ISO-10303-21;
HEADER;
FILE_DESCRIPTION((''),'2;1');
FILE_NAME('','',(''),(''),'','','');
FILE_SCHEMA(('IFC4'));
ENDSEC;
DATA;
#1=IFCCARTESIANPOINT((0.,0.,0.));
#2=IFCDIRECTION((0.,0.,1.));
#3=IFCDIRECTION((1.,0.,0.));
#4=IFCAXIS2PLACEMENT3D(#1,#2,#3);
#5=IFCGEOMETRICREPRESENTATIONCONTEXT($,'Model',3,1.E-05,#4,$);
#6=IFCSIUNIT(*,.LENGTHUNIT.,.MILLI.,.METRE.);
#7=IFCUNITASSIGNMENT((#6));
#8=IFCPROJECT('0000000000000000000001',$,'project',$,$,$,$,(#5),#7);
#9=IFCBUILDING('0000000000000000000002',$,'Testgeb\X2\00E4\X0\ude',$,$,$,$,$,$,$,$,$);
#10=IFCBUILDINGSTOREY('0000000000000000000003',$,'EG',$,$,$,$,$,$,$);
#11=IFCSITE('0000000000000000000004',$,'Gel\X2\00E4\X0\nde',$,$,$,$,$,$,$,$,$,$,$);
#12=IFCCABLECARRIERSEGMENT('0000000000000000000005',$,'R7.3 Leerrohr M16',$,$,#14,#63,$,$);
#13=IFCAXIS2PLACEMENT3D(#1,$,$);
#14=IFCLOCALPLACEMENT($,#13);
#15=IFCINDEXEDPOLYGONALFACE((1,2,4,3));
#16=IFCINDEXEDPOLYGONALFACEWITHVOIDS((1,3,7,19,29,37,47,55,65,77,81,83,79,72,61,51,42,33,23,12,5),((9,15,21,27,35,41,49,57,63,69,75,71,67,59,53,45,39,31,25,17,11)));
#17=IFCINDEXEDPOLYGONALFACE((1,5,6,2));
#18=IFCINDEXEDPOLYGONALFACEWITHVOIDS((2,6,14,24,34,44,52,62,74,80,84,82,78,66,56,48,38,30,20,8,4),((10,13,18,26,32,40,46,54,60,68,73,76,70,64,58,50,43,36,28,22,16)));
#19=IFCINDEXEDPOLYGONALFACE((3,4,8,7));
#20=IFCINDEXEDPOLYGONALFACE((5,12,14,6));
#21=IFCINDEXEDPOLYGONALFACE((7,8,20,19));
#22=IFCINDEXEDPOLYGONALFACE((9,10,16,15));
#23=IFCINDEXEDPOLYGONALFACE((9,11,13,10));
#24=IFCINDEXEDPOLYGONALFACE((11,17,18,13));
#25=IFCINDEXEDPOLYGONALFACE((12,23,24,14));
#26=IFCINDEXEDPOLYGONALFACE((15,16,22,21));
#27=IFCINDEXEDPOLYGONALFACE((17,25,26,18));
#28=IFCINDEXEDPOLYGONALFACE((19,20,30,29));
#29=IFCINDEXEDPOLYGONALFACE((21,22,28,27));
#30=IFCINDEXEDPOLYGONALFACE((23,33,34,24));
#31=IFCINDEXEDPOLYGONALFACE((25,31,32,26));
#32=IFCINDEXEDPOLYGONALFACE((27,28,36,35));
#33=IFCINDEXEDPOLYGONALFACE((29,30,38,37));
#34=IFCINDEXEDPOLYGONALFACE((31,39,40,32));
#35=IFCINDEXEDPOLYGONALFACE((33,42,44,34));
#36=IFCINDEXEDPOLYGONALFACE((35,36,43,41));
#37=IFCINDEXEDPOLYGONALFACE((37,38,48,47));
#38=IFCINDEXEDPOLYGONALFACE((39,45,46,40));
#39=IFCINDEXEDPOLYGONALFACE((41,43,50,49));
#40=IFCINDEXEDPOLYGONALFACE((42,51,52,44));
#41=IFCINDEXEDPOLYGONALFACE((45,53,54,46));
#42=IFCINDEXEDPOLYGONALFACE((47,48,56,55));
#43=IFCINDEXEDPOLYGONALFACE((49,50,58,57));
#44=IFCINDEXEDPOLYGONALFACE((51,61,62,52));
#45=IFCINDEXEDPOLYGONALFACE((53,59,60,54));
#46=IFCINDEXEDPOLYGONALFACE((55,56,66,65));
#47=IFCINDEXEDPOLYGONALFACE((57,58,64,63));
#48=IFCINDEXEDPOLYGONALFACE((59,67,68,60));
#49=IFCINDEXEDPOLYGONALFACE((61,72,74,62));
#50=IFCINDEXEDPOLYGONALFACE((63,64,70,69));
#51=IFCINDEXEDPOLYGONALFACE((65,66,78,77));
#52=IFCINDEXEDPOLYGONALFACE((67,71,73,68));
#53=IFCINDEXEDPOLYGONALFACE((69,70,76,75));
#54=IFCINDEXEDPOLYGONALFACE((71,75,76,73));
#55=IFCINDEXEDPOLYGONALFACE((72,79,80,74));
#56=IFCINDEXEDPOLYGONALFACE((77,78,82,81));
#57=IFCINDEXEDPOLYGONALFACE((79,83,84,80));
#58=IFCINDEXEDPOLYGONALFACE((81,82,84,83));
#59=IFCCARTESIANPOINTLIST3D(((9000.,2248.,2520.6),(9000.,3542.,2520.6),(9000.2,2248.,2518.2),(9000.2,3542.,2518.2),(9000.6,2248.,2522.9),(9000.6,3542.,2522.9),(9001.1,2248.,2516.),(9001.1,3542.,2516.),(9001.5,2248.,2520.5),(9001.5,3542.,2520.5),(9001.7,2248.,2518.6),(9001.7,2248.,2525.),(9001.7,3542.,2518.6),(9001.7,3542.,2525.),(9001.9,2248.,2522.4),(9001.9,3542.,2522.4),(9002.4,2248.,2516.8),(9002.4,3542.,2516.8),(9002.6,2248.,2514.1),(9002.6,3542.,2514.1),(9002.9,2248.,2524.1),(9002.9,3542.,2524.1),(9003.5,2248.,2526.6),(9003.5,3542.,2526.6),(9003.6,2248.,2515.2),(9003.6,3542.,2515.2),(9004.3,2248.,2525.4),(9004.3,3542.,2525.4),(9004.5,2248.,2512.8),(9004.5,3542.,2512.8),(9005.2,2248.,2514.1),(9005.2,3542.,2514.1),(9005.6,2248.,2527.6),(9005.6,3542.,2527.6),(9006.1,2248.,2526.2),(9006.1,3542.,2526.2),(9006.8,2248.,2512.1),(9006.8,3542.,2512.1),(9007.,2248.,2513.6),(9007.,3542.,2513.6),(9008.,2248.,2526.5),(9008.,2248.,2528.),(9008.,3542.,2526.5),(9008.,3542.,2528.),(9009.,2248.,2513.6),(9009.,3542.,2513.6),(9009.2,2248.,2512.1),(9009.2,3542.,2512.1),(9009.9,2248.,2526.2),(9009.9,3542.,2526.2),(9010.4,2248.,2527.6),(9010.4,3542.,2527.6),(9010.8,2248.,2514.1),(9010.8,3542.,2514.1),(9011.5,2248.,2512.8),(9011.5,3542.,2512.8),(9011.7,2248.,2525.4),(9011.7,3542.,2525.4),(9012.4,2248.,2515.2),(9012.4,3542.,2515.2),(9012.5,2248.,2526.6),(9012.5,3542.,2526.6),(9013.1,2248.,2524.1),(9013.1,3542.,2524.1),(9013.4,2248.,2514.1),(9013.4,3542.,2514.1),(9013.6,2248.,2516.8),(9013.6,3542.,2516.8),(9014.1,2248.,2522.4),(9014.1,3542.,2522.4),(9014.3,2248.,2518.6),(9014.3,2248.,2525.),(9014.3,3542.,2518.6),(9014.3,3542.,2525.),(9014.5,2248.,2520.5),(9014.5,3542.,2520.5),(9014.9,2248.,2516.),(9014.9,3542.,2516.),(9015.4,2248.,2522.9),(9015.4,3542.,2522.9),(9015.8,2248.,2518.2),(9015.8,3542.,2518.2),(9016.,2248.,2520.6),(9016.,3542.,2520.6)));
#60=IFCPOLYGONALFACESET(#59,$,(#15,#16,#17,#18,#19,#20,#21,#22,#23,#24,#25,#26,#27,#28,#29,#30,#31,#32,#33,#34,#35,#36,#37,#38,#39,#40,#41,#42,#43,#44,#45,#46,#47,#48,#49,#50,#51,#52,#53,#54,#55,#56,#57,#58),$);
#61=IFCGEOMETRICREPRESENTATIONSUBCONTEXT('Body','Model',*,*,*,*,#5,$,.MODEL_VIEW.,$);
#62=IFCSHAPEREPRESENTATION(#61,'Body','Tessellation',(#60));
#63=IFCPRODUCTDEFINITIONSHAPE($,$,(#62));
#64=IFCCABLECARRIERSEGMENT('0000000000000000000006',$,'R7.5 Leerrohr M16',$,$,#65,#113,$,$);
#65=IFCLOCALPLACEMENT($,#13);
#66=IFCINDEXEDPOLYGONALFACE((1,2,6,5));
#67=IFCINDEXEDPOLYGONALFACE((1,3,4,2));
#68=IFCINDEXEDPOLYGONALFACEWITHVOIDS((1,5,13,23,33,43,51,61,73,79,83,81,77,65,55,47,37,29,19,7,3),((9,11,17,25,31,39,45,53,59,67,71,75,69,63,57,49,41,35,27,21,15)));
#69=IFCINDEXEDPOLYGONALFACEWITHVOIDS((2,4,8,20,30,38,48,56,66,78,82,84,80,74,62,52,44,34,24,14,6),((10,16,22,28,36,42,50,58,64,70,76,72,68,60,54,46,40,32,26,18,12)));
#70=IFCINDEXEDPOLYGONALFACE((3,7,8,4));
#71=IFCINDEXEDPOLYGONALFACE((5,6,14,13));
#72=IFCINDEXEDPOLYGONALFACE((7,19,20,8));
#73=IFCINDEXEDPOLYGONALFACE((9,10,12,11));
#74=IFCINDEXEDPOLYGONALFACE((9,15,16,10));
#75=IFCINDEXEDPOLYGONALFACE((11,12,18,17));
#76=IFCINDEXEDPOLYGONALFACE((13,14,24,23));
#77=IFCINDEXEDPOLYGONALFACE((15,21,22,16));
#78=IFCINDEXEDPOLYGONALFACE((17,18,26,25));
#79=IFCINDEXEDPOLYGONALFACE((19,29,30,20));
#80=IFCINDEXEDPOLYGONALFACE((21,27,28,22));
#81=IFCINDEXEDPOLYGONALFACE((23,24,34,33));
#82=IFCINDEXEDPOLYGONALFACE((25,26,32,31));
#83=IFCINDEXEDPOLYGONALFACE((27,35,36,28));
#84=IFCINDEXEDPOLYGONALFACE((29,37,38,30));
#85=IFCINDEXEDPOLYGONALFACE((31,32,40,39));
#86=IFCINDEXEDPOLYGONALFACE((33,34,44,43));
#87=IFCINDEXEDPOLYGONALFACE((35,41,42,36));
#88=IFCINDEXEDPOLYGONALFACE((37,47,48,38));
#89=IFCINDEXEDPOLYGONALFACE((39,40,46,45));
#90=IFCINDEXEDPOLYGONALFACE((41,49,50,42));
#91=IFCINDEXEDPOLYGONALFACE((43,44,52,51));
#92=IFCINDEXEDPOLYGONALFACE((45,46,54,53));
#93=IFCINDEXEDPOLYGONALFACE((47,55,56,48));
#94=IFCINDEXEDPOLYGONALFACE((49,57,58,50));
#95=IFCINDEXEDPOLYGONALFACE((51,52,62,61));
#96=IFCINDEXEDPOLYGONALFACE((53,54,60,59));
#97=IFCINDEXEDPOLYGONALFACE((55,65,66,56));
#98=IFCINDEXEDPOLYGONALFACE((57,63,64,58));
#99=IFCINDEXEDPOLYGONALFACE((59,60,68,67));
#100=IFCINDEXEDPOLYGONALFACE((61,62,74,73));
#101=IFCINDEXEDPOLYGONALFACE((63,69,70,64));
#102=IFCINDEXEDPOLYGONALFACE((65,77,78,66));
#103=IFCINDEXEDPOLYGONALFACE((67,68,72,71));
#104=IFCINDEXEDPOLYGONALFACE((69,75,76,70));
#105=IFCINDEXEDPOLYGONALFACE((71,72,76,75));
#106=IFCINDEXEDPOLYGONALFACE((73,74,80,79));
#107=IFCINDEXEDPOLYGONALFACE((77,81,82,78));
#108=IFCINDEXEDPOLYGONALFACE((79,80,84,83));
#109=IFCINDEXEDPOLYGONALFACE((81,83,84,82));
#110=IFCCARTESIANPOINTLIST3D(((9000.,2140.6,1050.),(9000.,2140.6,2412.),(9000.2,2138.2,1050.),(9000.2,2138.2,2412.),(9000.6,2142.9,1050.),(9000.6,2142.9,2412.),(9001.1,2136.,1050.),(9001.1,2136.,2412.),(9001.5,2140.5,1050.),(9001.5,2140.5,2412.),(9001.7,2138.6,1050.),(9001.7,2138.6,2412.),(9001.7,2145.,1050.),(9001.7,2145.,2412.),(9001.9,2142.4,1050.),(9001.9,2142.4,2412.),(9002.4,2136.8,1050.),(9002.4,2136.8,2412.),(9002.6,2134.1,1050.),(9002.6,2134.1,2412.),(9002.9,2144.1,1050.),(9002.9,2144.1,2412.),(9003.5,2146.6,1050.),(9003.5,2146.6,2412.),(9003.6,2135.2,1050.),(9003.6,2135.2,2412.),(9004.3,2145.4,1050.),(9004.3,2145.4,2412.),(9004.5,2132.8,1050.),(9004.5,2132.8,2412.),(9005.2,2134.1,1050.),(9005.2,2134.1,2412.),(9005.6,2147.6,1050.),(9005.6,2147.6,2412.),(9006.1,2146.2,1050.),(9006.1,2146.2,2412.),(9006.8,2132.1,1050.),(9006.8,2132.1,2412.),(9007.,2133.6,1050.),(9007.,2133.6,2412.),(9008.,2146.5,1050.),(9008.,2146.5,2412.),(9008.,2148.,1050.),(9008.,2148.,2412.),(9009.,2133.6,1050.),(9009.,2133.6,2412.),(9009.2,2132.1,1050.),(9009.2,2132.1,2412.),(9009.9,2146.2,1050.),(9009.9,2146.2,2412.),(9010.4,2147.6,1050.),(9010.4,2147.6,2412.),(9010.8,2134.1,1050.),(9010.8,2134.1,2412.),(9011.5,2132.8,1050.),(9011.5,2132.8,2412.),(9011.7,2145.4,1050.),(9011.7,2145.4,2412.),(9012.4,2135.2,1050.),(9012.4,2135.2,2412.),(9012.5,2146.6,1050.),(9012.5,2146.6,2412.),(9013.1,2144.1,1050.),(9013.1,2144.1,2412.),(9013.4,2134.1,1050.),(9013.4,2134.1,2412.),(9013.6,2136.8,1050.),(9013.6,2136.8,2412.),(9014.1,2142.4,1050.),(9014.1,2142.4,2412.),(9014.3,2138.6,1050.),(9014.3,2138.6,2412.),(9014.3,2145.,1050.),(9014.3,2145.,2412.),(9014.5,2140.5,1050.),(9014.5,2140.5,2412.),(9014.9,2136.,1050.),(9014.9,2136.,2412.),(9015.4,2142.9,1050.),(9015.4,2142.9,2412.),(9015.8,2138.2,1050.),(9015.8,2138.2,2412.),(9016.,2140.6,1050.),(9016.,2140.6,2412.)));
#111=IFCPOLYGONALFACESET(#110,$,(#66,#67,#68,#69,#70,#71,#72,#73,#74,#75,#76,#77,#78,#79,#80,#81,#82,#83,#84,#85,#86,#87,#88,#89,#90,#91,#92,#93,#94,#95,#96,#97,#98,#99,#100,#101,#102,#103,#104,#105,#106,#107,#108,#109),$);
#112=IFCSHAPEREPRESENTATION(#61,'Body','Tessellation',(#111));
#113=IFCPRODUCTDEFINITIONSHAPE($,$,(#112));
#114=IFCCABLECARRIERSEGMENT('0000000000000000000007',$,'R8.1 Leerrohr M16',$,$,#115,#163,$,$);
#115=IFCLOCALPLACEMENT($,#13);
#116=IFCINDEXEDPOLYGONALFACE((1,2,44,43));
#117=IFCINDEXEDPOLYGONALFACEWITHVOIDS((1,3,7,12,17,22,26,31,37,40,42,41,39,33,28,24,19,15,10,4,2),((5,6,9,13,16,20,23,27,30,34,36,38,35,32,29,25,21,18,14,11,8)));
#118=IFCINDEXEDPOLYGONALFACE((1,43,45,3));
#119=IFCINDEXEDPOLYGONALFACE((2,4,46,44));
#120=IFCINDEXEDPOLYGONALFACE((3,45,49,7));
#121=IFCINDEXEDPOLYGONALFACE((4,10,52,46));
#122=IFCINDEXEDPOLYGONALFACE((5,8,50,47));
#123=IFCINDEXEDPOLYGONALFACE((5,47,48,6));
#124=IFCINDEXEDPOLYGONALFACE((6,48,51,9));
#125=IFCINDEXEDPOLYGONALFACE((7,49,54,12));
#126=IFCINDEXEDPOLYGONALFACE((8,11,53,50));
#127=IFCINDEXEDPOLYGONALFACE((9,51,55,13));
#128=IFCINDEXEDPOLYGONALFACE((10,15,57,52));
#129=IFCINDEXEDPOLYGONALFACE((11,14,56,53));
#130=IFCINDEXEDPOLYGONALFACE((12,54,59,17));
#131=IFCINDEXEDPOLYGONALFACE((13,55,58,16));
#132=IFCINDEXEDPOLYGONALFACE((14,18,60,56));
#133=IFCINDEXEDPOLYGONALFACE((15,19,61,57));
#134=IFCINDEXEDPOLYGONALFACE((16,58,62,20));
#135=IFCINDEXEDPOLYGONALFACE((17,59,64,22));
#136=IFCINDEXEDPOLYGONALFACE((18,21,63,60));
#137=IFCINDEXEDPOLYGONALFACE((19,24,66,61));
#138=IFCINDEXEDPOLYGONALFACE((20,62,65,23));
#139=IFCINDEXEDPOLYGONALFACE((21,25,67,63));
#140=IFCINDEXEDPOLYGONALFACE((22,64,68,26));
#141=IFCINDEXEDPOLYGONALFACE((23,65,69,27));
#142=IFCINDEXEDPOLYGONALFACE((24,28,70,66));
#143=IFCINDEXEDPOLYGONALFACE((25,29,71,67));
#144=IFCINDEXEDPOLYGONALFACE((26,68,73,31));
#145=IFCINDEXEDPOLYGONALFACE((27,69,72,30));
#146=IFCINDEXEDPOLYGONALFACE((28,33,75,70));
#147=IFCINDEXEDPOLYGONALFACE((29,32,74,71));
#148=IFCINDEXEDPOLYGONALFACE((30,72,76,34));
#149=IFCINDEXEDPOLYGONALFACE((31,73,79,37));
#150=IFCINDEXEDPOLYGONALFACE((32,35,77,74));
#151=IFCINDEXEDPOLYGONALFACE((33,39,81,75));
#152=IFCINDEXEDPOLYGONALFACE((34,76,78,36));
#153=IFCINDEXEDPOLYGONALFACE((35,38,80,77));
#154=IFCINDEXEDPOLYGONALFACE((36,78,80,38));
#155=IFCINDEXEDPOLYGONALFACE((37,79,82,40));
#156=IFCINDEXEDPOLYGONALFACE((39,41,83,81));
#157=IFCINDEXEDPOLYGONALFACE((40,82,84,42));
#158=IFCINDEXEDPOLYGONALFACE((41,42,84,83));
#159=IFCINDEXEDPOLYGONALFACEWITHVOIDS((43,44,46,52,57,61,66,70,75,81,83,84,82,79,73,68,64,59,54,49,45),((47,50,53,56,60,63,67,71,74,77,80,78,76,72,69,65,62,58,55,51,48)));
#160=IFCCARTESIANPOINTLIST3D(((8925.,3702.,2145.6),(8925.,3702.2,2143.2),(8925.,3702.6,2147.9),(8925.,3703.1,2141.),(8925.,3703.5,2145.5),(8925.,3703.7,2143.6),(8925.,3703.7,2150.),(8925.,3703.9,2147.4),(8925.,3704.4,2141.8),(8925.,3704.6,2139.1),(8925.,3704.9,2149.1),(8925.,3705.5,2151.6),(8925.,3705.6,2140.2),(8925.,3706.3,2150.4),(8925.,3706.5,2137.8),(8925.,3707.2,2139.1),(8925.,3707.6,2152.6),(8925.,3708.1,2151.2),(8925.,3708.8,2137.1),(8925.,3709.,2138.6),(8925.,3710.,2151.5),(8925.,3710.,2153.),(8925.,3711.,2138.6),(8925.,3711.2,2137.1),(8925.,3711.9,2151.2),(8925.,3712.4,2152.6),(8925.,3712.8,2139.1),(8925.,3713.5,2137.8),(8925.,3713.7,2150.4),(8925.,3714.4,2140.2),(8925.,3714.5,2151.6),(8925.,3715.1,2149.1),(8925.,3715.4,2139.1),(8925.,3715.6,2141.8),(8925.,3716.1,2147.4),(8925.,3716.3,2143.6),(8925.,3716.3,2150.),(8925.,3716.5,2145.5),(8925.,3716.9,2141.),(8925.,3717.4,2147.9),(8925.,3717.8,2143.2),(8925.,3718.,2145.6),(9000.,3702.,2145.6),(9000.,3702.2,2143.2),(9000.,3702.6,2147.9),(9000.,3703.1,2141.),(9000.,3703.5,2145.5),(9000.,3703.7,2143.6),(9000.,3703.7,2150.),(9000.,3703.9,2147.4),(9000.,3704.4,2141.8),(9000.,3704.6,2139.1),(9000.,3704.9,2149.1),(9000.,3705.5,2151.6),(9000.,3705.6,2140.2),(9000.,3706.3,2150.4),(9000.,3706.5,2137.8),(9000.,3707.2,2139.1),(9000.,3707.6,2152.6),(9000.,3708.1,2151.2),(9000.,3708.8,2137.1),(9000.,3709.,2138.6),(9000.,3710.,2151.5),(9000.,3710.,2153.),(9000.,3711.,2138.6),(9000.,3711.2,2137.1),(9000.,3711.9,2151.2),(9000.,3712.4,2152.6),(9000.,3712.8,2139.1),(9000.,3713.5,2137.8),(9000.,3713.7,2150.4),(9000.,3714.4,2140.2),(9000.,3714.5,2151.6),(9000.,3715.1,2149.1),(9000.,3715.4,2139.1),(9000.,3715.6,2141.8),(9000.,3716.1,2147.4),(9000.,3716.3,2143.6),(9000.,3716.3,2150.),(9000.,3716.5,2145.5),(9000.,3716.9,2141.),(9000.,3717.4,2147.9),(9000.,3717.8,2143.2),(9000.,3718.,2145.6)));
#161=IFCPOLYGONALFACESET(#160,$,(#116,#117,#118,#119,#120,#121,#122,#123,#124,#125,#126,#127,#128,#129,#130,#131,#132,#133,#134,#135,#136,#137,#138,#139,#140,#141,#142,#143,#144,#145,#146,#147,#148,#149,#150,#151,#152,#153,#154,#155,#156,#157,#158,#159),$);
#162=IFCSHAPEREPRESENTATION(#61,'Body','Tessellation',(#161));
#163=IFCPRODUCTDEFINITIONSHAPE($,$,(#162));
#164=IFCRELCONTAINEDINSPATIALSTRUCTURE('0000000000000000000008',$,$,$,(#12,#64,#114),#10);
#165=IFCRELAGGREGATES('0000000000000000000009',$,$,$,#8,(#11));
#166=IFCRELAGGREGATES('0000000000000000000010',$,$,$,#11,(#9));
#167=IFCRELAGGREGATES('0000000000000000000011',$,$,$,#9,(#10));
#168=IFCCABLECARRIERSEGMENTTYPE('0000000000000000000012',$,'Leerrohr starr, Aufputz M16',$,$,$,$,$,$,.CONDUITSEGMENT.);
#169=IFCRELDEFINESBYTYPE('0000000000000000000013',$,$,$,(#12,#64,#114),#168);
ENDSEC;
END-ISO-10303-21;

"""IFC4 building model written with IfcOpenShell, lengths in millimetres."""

from ifc_helpers import new_model, si_unit, frame, origin_with_axes, place, context, subcontext, project, spatial, hollow_circle, extrude, type_object, element, save


model = new_model("IFC4")

# Units and contexts
model_context = context("Model", 3, precision=1e-05, world=origin_with_axes())
body_context = subcontext(model_context, "Body", "Model", "MODEL_VIEW")
ifc_project = project(units=[si_unit("LENGTHUNIT", "METRE", prefix="MILLI")], contexts=[model_context])

# Site, building, storey
site = spatial("IfcSite", under=ifc_project, Name="Gelände")
building = spatial("IfcBuilding", under=site, Name="Testgebäude")
storey = spatial("IfcBuildingStorey", under=building, Name="EG")

# Cable carrier segments
cable_carrier_segment_type_1 = type_object("IfcCableCarrierSegmentType", Name="Leerrohr starr, Aufputz M16", PredefinedType="CONDUITSEGMENT")
cable_carrier_segment_1_placement = place(None, frame((9008.0, 3542.0, 2520.0), z_axis=(0.0, -1.0, 0.0), x_axis=(0.0, 0.0, 1.0)))
element("IfcCableCarrierSegment", 1, at=cable_carrier_segment_1_placement, inside=storey, type_object=cable_carrier_segment_type_1, Name="R7.3 Leerrohr M16", context=body_context, shape_type="SweptSolid", body=[
    extrude(hollow_circle(Radius=8.0, WallThickness=1.5), None, (0.0, 0.0, 1.0), 1294.0),
])
cable_carrier_segment_2_placement = place(None, frame((9008.0, 2140.0, 2412.0), z_axis=(0.0, 0.0, -1.0), x_axis=(0.0, 1.0, 0.0)))
element("IfcCableCarrierSegment", 2, at=cable_carrier_segment_2_placement, inside=storey, type_object=cable_carrier_segment_type_1, Name="R7.5 Leerrohr M16", context=body_context, shape_type="SweptSolid", body=[
    extrude(hollow_circle(Radius=8.0, WallThickness=1.5), None, (0.0, 0.0, 1.0), 1362.0),
])
cable_carrier_segment_3_placement = place(None, frame((9000.0, 3710.0, 2145.0), z_axis=(-1.0, 0.0, 0.0), x_axis=(0.0, 0.0, 1.0)))
element("IfcCableCarrierSegment", 3, at=cable_carrier_segment_3_placement, inside=storey, type_object=cable_carrier_segment_type_1, Name="R8.1 Leerrohr M16", context=body_context, shape_type="SweptSolid", body=[
    extrude(hollow_circle(Radius=8.0, WallThickness=1.5), None, (0.0, 0.0, 1.0), 75.0),
])

save(model, "model.ifc")
